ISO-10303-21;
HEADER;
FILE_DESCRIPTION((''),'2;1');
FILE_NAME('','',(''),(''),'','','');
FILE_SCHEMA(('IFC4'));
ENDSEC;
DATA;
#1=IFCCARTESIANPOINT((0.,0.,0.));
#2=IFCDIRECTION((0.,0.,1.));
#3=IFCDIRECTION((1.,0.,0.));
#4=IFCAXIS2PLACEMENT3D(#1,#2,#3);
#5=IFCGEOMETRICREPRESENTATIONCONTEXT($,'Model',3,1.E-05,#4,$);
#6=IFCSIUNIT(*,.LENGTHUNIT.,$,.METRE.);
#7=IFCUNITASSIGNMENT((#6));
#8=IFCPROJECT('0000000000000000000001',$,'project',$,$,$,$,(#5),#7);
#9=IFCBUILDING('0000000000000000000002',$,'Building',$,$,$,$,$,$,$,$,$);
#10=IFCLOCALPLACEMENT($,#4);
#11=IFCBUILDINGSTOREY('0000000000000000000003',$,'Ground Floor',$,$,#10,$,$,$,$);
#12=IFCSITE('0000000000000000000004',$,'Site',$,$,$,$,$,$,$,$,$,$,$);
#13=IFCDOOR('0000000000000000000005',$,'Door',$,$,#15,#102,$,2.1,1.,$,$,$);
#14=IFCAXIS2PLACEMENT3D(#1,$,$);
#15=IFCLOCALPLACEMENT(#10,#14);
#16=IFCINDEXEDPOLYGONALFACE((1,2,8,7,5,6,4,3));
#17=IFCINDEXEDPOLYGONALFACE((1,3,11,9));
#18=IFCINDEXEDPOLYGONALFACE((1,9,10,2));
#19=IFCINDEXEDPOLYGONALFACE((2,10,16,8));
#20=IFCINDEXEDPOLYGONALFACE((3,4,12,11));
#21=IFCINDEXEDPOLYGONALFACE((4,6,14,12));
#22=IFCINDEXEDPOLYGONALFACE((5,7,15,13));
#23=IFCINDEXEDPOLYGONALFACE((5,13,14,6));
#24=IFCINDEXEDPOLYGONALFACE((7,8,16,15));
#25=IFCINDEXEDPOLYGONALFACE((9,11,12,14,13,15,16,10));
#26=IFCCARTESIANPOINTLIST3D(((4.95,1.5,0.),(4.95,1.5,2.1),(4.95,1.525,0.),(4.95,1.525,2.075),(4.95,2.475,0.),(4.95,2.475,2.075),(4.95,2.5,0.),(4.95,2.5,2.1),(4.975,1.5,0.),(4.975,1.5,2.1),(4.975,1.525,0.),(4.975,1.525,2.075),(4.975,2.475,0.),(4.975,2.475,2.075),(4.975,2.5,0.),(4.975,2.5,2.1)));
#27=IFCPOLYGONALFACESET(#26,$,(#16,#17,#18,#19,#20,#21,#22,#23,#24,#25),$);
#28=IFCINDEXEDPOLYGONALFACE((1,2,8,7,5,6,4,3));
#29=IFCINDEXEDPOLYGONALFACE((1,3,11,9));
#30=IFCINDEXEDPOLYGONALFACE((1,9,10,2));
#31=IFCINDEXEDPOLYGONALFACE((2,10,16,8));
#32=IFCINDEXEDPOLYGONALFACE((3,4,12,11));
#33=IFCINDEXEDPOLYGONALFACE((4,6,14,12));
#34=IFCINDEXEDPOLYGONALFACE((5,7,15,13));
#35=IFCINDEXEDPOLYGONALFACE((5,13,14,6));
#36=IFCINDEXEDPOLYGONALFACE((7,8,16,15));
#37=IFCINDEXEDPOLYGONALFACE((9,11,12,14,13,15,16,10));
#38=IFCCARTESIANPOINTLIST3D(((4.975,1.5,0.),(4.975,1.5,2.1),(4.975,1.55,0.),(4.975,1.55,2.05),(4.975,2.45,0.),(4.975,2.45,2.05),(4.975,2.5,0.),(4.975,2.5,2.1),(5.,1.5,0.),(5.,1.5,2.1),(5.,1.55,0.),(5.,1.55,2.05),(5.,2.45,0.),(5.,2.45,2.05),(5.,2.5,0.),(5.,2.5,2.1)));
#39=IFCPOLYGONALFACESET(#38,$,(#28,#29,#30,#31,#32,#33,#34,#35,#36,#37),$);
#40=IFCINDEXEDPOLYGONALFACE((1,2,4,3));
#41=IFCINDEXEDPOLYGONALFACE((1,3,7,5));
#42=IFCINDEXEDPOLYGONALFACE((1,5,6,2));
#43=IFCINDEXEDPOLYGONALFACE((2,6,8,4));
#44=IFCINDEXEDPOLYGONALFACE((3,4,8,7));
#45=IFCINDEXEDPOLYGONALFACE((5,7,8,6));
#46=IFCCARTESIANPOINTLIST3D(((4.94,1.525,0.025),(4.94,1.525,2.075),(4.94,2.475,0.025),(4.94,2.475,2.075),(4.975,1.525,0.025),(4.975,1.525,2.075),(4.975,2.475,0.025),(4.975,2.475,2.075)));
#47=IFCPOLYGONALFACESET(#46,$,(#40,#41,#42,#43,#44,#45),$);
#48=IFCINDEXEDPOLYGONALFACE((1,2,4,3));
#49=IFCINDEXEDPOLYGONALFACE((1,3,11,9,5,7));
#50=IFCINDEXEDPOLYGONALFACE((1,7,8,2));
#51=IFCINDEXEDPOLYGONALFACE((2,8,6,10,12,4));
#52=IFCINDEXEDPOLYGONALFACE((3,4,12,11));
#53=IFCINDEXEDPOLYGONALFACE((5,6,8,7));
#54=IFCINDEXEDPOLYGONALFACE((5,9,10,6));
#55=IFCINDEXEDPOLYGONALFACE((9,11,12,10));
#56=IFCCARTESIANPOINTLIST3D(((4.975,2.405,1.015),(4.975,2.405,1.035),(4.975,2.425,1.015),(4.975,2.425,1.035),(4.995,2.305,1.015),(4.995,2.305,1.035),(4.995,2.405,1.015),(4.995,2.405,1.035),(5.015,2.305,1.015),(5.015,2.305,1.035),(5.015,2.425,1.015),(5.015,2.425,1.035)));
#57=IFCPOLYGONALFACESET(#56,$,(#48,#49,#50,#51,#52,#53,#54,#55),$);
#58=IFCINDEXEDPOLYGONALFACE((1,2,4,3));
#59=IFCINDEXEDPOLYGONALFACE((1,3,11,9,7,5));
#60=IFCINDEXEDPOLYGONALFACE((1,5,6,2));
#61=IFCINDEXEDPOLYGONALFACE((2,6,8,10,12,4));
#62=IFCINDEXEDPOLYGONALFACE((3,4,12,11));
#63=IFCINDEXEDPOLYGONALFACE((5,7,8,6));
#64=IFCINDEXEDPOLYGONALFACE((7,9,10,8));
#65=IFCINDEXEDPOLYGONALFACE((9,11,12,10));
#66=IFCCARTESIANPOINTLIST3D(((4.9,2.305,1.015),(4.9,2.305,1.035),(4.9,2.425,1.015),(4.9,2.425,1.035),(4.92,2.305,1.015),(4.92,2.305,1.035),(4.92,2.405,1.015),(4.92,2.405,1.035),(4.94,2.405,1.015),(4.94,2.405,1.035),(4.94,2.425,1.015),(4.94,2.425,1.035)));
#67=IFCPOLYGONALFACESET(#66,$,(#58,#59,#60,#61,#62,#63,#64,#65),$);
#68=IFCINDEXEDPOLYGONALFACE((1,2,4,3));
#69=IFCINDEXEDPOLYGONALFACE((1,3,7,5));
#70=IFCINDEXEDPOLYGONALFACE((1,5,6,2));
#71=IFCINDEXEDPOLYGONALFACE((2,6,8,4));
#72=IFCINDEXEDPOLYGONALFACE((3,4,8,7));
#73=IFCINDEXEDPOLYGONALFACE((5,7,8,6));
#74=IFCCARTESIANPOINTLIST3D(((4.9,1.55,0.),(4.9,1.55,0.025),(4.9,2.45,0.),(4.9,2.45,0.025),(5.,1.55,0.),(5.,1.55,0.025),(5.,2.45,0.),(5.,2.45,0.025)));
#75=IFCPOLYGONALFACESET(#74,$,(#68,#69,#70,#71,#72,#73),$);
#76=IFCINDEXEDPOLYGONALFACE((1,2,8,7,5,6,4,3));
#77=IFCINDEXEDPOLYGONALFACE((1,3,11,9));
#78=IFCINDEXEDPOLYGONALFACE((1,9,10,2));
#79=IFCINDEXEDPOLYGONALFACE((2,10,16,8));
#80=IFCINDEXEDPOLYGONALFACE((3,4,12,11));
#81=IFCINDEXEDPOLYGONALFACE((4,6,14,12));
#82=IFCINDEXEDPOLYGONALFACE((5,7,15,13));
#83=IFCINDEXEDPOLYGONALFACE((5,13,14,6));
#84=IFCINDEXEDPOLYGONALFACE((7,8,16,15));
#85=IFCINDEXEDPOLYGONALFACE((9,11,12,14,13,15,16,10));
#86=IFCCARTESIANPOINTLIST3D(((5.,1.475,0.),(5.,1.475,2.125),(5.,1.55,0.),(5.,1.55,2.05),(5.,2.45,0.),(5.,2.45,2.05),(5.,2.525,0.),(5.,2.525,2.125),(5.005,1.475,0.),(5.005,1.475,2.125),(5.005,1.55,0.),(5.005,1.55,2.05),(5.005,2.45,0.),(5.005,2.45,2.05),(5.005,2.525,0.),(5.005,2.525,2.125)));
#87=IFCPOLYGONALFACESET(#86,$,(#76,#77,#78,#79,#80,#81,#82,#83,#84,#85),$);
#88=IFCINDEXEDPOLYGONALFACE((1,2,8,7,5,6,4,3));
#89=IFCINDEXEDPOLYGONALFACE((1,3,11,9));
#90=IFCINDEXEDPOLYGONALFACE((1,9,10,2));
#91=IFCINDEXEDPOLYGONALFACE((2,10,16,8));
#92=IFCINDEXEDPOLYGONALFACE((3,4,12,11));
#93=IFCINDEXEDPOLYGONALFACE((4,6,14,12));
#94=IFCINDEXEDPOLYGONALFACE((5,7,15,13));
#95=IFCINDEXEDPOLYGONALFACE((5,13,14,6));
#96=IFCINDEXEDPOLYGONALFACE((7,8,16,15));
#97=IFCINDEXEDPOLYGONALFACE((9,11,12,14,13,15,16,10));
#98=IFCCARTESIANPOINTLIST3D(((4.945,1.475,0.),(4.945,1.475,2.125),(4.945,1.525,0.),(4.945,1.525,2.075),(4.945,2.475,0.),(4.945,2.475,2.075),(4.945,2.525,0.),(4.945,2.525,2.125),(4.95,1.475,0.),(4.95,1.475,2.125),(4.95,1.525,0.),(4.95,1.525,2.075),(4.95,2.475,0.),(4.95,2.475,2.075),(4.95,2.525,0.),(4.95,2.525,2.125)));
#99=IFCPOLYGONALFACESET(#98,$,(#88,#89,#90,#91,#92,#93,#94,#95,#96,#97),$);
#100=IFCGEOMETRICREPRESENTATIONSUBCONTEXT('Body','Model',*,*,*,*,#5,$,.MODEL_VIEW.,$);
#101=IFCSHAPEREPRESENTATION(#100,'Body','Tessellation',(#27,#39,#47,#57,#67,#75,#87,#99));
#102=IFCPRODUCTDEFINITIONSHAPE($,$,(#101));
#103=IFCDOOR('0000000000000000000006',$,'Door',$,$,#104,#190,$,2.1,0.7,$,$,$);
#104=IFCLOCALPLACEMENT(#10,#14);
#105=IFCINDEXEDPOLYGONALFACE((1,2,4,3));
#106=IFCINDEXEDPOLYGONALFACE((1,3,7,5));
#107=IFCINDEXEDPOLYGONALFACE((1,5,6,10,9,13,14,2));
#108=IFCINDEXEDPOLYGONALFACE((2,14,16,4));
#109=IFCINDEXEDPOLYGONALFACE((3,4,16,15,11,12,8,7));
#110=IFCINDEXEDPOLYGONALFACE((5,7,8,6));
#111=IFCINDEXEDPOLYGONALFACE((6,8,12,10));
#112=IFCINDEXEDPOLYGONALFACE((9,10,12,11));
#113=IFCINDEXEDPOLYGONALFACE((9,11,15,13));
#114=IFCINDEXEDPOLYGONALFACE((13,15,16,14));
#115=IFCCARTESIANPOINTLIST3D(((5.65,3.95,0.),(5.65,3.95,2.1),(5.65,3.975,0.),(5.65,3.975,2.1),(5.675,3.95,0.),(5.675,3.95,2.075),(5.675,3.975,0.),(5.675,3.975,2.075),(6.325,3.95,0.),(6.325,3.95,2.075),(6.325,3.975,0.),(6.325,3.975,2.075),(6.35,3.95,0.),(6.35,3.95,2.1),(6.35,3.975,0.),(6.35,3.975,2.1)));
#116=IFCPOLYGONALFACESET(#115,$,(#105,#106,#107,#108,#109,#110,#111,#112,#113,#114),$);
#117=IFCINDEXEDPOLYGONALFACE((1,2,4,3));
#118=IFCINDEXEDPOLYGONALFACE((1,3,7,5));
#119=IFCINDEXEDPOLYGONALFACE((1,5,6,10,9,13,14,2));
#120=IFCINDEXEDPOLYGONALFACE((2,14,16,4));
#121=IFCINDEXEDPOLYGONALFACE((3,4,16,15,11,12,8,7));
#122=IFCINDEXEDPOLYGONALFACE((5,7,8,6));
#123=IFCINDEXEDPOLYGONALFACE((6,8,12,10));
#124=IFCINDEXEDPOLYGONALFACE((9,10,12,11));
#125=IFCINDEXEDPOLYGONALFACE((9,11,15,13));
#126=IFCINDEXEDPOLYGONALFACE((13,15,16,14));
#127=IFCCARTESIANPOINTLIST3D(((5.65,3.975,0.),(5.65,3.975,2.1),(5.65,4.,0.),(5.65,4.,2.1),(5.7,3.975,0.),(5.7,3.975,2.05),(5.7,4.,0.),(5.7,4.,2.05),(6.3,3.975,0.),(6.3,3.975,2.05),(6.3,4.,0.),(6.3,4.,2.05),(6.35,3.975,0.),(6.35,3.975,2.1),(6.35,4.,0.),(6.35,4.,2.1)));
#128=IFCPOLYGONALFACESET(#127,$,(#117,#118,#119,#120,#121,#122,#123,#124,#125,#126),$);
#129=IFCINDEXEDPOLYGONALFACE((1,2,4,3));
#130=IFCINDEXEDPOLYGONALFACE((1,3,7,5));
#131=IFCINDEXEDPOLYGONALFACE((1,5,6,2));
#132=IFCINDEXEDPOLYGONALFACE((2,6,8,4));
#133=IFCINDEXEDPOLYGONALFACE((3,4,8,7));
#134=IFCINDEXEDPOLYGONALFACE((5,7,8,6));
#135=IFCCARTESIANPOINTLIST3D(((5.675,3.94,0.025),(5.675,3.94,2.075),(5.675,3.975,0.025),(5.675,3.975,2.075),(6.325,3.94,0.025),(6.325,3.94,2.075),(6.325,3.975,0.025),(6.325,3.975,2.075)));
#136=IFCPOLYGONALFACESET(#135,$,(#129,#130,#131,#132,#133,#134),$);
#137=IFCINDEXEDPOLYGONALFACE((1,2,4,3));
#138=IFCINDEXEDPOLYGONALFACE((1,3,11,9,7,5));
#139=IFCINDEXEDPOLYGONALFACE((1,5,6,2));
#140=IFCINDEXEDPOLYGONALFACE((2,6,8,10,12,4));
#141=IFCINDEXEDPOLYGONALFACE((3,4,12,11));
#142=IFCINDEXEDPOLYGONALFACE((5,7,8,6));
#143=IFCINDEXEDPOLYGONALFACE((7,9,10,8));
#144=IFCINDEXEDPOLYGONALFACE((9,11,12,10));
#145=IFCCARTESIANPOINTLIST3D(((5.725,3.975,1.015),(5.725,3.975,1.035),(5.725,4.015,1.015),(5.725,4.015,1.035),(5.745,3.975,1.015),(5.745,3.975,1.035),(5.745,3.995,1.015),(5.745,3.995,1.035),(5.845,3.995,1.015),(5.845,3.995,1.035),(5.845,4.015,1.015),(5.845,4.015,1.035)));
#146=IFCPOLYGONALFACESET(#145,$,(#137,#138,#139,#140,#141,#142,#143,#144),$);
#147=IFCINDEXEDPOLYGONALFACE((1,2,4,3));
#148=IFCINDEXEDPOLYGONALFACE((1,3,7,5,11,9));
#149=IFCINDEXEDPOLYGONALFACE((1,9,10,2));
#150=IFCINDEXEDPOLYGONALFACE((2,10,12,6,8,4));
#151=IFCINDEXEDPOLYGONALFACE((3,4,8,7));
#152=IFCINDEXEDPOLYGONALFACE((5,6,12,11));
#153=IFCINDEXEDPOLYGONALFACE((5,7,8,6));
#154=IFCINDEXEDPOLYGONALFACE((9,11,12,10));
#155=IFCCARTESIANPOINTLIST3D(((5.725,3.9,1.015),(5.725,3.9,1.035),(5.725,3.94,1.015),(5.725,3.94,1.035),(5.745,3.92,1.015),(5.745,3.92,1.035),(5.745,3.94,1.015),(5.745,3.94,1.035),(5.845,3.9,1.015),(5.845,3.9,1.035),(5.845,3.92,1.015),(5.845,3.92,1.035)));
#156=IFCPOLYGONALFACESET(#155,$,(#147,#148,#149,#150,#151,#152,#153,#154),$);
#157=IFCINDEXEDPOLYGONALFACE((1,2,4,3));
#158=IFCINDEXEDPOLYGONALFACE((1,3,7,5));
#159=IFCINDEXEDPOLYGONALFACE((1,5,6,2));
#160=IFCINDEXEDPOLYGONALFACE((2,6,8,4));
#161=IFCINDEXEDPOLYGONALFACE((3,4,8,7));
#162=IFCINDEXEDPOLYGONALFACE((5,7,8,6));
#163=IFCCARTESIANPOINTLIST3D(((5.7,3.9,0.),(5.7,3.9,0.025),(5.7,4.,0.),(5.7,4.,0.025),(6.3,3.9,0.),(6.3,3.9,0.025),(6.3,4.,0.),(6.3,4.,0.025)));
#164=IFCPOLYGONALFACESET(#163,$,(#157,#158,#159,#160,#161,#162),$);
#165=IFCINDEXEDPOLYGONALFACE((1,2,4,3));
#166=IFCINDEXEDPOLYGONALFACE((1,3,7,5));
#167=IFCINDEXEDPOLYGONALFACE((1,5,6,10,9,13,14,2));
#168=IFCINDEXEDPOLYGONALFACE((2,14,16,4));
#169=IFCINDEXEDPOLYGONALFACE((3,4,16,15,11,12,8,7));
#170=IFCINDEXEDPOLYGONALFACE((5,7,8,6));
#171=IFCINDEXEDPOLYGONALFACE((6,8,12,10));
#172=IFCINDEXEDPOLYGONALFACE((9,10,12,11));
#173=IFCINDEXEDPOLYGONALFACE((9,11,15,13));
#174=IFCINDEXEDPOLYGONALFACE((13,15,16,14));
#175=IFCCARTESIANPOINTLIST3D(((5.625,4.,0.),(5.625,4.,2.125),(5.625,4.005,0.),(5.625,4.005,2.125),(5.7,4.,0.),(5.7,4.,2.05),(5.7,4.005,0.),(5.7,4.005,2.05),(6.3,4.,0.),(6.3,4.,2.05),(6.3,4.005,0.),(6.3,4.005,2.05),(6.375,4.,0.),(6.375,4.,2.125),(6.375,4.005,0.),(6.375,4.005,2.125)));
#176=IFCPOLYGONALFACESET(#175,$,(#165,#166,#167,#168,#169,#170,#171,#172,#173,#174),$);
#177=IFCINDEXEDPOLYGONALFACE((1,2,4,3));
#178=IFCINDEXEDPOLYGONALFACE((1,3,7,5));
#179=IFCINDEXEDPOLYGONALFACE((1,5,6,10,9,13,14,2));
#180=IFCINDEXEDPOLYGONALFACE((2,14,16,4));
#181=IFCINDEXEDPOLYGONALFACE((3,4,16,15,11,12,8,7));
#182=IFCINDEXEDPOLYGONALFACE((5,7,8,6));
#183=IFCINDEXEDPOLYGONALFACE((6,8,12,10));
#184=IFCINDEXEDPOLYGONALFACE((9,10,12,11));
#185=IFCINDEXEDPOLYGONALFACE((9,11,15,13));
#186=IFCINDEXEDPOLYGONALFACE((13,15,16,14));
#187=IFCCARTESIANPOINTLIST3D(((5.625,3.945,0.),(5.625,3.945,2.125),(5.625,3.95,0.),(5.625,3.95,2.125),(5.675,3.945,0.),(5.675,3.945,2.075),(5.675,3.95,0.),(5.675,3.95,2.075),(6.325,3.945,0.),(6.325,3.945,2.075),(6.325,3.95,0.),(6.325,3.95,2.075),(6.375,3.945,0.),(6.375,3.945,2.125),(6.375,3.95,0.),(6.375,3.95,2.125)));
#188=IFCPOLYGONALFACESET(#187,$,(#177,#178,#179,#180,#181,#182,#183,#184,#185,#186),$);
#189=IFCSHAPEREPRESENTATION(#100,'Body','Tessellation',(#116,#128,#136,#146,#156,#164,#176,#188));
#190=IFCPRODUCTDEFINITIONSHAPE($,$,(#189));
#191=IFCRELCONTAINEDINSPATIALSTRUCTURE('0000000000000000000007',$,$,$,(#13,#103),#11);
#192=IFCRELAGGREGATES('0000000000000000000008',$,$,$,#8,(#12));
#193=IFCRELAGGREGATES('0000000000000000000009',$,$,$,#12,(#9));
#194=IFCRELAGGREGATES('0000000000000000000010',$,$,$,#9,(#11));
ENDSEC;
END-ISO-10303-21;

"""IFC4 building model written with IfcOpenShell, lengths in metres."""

from ifc_helpers import new_model, si_unit, frame, origin_with_axes, place, context, subcontext, project, spatial, line, indexed_curve, outline, extrude, element, save


model = new_model("IFC4")

# Units and contexts
model_context = context("Model", 3, precision=1e-05, world=origin_with_axes())
body_context = subcontext(model_context, "Body", "Model", "MODEL_VIEW")
ifc_project = project(units=[si_unit("LENGTHUNIT", "METRE")], contexts=[model_context])

# Site, building, storey
site = spatial("IfcSite", under=ifc_project, Name="Site")
building = spatial("IfcBuilding", under=site, Name="Building")
storey_placement = place(None, origin_with_axes())
storey = spatial("IfcBuildingStorey", under=building, at=storey_placement, Name="Ground Floor")

# Doors
door_1_placement = place(storey_placement, frame((5.0, 1.5, 0.0), z_axis=(0.0, 0.0, 1.0), x_axis=(0.0, 1.0, 0.0)))
element("IfcDoor", 1, at=door_1_placement, inside=storey, Name="Door", OverallHeight=2.1, OverallWidth=1.0, context=body_context, shape_type="SweptSolid", body=[
    extrude(outline(indexed_curve([(0.0, 0.0), (0.0, 2.1), (1.0, 2.1), (1.0, 0.0), (0.975, 0.0), (0.975, 2.075), (0.025, 2.075), (0.025, 0.0)], segments=[line(1, 2, 3, 4, 5, 6, 7, 8, 1)])), frame((0.0, 0.025, 0.0), z_axis=(0.0, -1.0, 0.0), x_axis=(1.0, 0.0, 0.0)), (0.0, 0.0, -1.0), 0.025),
    extrude(outline(indexed_curve([(0.0, 0.0), (0.0, 2.1), (1.0, 2.1), (1.0, 0.0), (0.95, 0.0), (0.95, 2.05), (0.05, 2.05), (0.05, 0.0)], segments=[line(1, 2, 3, 4, 5, 6, 7, 8, 1)])), frame((0.0, 0.0, 0.0), z_axis=(0.0, -1.0, 0.0), x_axis=(1.0, 0.0, 0.0)), (0.0, 0.0, -1.0), 0.025),
    extrude(outline(indexed_curve([(0.0, 0.0), (0.95, 0.0), (0.95, 0.035), (0.0, 0.035)], segments=[line(1, 2, 3, 4, 1)])), frame((0.025, 0.025, 0.025), z_axis=(0.0, 0.0, 1.0), x_axis=(1.0, 0.0, 0.0)), (0.0, 0.0, 1.0), 2.05),
    extrude(outline(indexed_curve([(0.0, 0.0), (0.0, -0.04), (-0.12, -0.04), (-0.12, -0.02), (-0.02, -0.02), (-0.02, 0.0)], segments=[line(1, 2, 3, 4, 5, 6, 1)])), frame((0.925, 0.025, 1.015), z_axis=(0.0, 0.0, 1.0), x_axis=(1.0, 0.0, 0.0)), (0.0, 0.0, 1.0), 0.02),
    extrude(outline(indexed_curve([(0.0, 0.0), (0.0, 0.04), (-0.12, 0.04), (-0.12, 0.02), (-0.02, 0.02), (-0.02, 0.0)], segments=[line(1, 2, 3, 4, 5, 6, 1)])), frame((0.925, 0.06, 1.015), z_axis=(0.0, 0.0, 1.0), x_axis=(1.0, 0.0, 0.0)), (0.0, 0.0, 1.0), 0.02),
    extrude(outline(indexed_curve([(0.0, 0.0), (0.9, 0.0), (0.9, 0.1), (0.0, 0.1)], segments=[line(1, 2, 3, 4, 1)])), frame((0.05, 0.0, 0.0), z_axis=(0.0, 0.0, 1.0), x_axis=(1.0, 0.0, 0.0)), (0.0, 0.0, 1.0), 0.025),
    extrude(outline(indexed_curve([(0.0, 0.0), (0.0, 2.125), (1.05, 2.125), (1.05, 0.0), (0.975, 0.0), (0.975, 2.05), (0.075, 2.05), (0.075, 0.0)], segments=[line(1, 2, 3, 4, 5, 6, 7, 8, 1)])), frame((-0.025, -0.005, 0.0), z_axis=(0.0, -1.0, 0.0), x_axis=(1.0, 0.0, 0.0)), (0.0, 0.0, -1.0), 0.005),
    extrude(outline(indexed_curve([(0.0, 0.0), (0.0, 2.125), (1.05, 2.125), (1.05, 0.0), (1.0, 0.0), (1.0, 2.075), (0.05, 2.075), (0.05, 0.0)], segments=[line(1, 2, 3, 4, 5, 6, 7, 8, 1)])), frame((-0.025, 0.05, 0.0), z_axis=(0.0, -1.0, 0.0), x_axis=(1.0, 0.0, 0.0)), (0.0, 0.0, -1.0), 0.005),
])
door_2_placement = place(storey_placement, frame((6.35, 4.0, 0.0), z_axis=(0.0, 0.0, 1.0), x_axis=(-1.0, 0.0, 0.0)))
element("IfcDoor", 2, at=door_2_placement, inside=storey, Name="Door", OverallHeight=2.1, OverallWidth=0.7, context=body_context, shape_type="SweptSolid", body=[
    extrude(outline(indexed_curve([(0.0, 0.0), (0.0, 2.1), (0.7, 2.1), (0.7, 0.0), (0.675, 0.0), (0.675, 2.075), (0.025, 2.075), (0.025, 0.0)], segments=[line(1, 2, 3, 4, 5, 6, 7, 8, 1)])), frame((0.0, 0.025, 0.0), z_axis=(0.0, -1.0, 0.0), x_axis=(1.0, 0.0, 0.0)), (0.0, 0.0, -1.0), 0.025),
    extrude(outline(indexed_curve([(0.0, 0.0), (0.0, 2.1), (0.7, 2.1), (0.7, 0.0), (0.65, 0.0), (0.65, 2.05), (0.05, 2.05), (0.05, 0.0)], segments=[line(1, 2, 3, 4, 5, 6, 7, 8, 1)])), frame((0.0, 0.0, 0.0), z_axis=(0.0, -1.0, 0.0), x_axis=(1.0, 0.0, 0.0)), (0.0, 0.0, -1.0), 0.025),
    extrude(outline(indexed_curve([(0.0, 0.0), (0.65, 0.0), (0.65, 0.035), (0.0, 0.035)], segments=[line(1, 2, 3, 4, 1)])), frame((0.025, 0.025, 0.025), z_axis=(0.0, 0.0, 1.0), x_axis=(1.0, 0.0, 0.0)), (0.0, 0.0, 1.0), 2.05),
    extrude(outline(indexed_curve([(0.0, 0.0), (0.0, -0.04), (-0.12, -0.04), (-0.12, -0.02), (-0.02, -0.02), (-0.02, 0.0)], segments=[line(1, 2, 3, 4, 5, 6, 1)])), frame((0.625, 0.025, 1.015), z_axis=(0.0, 0.0, 1.0), x_axis=(1.0, 0.0, 0.0)), (0.0, 0.0, 1.0), 0.02),
    extrude(outline(indexed_curve([(0.0, 0.0), (0.0, 0.04), (-0.12, 0.04), (-0.12, 0.02), (-0.02, 0.02), (-0.02, 0.0)], segments=[line(1, 2, 3, 4, 5, 6, 1)])), frame((0.625, 0.06, 1.015), z_axis=(0.0, 0.0, 1.0), x_axis=(1.0, 0.0, 0.0)), (0.0, 0.0, 1.0), 0.02),
    extrude(outline(indexed_curve([(0.0, 0.0), (0.6, 0.0), (0.6, 0.1), (0.0, 0.1)], segments=[line(1, 2, 3, 4, 1)])), frame((0.05, 0.0, 0.0), z_axis=(0.0, 0.0, 1.0), x_axis=(1.0, 0.0, 0.0)), (0.0, 0.0, 1.0), 0.025),
    extrude(outline(indexed_curve([(0.0, 0.0), (0.0, 2.125), (0.75, 2.125), (0.75, 0.0), (0.675, 0.0), (0.675, 2.05), (0.075, 2.05), (0.075, 0.0)], segments=[line(1, 2, 3, 4, 5, 6, 7, 8, 1)])), frame((-0.025, -0.005, 0.0), z_axis=(0.0, -1.0, 0.0), x_axis=(1.0, 0.0, 0.0)), (0.0, 0.0, -1.0), 0.005),
    extrude(outline(indexed_curve([(0.0, 0.0), (0.0, 2.125), (0.75, 2.125), (0.75, 0.0), (0.7, 0.0), (0.7, 2.075), (0.05, 2.075), (0.05, 0.0)], segments=[line(1, 2, 3, 4, 5, 6, 7, 8, 1)])), frame((-0.025, 0.05, 0.0), z_axis=(0.0, -1.0, 0.0), x_axis=(1.0, 0.0, 0.0)), (0.0, 0.0, -1.0), 0.005),
])

save(model, "model.ifc")
